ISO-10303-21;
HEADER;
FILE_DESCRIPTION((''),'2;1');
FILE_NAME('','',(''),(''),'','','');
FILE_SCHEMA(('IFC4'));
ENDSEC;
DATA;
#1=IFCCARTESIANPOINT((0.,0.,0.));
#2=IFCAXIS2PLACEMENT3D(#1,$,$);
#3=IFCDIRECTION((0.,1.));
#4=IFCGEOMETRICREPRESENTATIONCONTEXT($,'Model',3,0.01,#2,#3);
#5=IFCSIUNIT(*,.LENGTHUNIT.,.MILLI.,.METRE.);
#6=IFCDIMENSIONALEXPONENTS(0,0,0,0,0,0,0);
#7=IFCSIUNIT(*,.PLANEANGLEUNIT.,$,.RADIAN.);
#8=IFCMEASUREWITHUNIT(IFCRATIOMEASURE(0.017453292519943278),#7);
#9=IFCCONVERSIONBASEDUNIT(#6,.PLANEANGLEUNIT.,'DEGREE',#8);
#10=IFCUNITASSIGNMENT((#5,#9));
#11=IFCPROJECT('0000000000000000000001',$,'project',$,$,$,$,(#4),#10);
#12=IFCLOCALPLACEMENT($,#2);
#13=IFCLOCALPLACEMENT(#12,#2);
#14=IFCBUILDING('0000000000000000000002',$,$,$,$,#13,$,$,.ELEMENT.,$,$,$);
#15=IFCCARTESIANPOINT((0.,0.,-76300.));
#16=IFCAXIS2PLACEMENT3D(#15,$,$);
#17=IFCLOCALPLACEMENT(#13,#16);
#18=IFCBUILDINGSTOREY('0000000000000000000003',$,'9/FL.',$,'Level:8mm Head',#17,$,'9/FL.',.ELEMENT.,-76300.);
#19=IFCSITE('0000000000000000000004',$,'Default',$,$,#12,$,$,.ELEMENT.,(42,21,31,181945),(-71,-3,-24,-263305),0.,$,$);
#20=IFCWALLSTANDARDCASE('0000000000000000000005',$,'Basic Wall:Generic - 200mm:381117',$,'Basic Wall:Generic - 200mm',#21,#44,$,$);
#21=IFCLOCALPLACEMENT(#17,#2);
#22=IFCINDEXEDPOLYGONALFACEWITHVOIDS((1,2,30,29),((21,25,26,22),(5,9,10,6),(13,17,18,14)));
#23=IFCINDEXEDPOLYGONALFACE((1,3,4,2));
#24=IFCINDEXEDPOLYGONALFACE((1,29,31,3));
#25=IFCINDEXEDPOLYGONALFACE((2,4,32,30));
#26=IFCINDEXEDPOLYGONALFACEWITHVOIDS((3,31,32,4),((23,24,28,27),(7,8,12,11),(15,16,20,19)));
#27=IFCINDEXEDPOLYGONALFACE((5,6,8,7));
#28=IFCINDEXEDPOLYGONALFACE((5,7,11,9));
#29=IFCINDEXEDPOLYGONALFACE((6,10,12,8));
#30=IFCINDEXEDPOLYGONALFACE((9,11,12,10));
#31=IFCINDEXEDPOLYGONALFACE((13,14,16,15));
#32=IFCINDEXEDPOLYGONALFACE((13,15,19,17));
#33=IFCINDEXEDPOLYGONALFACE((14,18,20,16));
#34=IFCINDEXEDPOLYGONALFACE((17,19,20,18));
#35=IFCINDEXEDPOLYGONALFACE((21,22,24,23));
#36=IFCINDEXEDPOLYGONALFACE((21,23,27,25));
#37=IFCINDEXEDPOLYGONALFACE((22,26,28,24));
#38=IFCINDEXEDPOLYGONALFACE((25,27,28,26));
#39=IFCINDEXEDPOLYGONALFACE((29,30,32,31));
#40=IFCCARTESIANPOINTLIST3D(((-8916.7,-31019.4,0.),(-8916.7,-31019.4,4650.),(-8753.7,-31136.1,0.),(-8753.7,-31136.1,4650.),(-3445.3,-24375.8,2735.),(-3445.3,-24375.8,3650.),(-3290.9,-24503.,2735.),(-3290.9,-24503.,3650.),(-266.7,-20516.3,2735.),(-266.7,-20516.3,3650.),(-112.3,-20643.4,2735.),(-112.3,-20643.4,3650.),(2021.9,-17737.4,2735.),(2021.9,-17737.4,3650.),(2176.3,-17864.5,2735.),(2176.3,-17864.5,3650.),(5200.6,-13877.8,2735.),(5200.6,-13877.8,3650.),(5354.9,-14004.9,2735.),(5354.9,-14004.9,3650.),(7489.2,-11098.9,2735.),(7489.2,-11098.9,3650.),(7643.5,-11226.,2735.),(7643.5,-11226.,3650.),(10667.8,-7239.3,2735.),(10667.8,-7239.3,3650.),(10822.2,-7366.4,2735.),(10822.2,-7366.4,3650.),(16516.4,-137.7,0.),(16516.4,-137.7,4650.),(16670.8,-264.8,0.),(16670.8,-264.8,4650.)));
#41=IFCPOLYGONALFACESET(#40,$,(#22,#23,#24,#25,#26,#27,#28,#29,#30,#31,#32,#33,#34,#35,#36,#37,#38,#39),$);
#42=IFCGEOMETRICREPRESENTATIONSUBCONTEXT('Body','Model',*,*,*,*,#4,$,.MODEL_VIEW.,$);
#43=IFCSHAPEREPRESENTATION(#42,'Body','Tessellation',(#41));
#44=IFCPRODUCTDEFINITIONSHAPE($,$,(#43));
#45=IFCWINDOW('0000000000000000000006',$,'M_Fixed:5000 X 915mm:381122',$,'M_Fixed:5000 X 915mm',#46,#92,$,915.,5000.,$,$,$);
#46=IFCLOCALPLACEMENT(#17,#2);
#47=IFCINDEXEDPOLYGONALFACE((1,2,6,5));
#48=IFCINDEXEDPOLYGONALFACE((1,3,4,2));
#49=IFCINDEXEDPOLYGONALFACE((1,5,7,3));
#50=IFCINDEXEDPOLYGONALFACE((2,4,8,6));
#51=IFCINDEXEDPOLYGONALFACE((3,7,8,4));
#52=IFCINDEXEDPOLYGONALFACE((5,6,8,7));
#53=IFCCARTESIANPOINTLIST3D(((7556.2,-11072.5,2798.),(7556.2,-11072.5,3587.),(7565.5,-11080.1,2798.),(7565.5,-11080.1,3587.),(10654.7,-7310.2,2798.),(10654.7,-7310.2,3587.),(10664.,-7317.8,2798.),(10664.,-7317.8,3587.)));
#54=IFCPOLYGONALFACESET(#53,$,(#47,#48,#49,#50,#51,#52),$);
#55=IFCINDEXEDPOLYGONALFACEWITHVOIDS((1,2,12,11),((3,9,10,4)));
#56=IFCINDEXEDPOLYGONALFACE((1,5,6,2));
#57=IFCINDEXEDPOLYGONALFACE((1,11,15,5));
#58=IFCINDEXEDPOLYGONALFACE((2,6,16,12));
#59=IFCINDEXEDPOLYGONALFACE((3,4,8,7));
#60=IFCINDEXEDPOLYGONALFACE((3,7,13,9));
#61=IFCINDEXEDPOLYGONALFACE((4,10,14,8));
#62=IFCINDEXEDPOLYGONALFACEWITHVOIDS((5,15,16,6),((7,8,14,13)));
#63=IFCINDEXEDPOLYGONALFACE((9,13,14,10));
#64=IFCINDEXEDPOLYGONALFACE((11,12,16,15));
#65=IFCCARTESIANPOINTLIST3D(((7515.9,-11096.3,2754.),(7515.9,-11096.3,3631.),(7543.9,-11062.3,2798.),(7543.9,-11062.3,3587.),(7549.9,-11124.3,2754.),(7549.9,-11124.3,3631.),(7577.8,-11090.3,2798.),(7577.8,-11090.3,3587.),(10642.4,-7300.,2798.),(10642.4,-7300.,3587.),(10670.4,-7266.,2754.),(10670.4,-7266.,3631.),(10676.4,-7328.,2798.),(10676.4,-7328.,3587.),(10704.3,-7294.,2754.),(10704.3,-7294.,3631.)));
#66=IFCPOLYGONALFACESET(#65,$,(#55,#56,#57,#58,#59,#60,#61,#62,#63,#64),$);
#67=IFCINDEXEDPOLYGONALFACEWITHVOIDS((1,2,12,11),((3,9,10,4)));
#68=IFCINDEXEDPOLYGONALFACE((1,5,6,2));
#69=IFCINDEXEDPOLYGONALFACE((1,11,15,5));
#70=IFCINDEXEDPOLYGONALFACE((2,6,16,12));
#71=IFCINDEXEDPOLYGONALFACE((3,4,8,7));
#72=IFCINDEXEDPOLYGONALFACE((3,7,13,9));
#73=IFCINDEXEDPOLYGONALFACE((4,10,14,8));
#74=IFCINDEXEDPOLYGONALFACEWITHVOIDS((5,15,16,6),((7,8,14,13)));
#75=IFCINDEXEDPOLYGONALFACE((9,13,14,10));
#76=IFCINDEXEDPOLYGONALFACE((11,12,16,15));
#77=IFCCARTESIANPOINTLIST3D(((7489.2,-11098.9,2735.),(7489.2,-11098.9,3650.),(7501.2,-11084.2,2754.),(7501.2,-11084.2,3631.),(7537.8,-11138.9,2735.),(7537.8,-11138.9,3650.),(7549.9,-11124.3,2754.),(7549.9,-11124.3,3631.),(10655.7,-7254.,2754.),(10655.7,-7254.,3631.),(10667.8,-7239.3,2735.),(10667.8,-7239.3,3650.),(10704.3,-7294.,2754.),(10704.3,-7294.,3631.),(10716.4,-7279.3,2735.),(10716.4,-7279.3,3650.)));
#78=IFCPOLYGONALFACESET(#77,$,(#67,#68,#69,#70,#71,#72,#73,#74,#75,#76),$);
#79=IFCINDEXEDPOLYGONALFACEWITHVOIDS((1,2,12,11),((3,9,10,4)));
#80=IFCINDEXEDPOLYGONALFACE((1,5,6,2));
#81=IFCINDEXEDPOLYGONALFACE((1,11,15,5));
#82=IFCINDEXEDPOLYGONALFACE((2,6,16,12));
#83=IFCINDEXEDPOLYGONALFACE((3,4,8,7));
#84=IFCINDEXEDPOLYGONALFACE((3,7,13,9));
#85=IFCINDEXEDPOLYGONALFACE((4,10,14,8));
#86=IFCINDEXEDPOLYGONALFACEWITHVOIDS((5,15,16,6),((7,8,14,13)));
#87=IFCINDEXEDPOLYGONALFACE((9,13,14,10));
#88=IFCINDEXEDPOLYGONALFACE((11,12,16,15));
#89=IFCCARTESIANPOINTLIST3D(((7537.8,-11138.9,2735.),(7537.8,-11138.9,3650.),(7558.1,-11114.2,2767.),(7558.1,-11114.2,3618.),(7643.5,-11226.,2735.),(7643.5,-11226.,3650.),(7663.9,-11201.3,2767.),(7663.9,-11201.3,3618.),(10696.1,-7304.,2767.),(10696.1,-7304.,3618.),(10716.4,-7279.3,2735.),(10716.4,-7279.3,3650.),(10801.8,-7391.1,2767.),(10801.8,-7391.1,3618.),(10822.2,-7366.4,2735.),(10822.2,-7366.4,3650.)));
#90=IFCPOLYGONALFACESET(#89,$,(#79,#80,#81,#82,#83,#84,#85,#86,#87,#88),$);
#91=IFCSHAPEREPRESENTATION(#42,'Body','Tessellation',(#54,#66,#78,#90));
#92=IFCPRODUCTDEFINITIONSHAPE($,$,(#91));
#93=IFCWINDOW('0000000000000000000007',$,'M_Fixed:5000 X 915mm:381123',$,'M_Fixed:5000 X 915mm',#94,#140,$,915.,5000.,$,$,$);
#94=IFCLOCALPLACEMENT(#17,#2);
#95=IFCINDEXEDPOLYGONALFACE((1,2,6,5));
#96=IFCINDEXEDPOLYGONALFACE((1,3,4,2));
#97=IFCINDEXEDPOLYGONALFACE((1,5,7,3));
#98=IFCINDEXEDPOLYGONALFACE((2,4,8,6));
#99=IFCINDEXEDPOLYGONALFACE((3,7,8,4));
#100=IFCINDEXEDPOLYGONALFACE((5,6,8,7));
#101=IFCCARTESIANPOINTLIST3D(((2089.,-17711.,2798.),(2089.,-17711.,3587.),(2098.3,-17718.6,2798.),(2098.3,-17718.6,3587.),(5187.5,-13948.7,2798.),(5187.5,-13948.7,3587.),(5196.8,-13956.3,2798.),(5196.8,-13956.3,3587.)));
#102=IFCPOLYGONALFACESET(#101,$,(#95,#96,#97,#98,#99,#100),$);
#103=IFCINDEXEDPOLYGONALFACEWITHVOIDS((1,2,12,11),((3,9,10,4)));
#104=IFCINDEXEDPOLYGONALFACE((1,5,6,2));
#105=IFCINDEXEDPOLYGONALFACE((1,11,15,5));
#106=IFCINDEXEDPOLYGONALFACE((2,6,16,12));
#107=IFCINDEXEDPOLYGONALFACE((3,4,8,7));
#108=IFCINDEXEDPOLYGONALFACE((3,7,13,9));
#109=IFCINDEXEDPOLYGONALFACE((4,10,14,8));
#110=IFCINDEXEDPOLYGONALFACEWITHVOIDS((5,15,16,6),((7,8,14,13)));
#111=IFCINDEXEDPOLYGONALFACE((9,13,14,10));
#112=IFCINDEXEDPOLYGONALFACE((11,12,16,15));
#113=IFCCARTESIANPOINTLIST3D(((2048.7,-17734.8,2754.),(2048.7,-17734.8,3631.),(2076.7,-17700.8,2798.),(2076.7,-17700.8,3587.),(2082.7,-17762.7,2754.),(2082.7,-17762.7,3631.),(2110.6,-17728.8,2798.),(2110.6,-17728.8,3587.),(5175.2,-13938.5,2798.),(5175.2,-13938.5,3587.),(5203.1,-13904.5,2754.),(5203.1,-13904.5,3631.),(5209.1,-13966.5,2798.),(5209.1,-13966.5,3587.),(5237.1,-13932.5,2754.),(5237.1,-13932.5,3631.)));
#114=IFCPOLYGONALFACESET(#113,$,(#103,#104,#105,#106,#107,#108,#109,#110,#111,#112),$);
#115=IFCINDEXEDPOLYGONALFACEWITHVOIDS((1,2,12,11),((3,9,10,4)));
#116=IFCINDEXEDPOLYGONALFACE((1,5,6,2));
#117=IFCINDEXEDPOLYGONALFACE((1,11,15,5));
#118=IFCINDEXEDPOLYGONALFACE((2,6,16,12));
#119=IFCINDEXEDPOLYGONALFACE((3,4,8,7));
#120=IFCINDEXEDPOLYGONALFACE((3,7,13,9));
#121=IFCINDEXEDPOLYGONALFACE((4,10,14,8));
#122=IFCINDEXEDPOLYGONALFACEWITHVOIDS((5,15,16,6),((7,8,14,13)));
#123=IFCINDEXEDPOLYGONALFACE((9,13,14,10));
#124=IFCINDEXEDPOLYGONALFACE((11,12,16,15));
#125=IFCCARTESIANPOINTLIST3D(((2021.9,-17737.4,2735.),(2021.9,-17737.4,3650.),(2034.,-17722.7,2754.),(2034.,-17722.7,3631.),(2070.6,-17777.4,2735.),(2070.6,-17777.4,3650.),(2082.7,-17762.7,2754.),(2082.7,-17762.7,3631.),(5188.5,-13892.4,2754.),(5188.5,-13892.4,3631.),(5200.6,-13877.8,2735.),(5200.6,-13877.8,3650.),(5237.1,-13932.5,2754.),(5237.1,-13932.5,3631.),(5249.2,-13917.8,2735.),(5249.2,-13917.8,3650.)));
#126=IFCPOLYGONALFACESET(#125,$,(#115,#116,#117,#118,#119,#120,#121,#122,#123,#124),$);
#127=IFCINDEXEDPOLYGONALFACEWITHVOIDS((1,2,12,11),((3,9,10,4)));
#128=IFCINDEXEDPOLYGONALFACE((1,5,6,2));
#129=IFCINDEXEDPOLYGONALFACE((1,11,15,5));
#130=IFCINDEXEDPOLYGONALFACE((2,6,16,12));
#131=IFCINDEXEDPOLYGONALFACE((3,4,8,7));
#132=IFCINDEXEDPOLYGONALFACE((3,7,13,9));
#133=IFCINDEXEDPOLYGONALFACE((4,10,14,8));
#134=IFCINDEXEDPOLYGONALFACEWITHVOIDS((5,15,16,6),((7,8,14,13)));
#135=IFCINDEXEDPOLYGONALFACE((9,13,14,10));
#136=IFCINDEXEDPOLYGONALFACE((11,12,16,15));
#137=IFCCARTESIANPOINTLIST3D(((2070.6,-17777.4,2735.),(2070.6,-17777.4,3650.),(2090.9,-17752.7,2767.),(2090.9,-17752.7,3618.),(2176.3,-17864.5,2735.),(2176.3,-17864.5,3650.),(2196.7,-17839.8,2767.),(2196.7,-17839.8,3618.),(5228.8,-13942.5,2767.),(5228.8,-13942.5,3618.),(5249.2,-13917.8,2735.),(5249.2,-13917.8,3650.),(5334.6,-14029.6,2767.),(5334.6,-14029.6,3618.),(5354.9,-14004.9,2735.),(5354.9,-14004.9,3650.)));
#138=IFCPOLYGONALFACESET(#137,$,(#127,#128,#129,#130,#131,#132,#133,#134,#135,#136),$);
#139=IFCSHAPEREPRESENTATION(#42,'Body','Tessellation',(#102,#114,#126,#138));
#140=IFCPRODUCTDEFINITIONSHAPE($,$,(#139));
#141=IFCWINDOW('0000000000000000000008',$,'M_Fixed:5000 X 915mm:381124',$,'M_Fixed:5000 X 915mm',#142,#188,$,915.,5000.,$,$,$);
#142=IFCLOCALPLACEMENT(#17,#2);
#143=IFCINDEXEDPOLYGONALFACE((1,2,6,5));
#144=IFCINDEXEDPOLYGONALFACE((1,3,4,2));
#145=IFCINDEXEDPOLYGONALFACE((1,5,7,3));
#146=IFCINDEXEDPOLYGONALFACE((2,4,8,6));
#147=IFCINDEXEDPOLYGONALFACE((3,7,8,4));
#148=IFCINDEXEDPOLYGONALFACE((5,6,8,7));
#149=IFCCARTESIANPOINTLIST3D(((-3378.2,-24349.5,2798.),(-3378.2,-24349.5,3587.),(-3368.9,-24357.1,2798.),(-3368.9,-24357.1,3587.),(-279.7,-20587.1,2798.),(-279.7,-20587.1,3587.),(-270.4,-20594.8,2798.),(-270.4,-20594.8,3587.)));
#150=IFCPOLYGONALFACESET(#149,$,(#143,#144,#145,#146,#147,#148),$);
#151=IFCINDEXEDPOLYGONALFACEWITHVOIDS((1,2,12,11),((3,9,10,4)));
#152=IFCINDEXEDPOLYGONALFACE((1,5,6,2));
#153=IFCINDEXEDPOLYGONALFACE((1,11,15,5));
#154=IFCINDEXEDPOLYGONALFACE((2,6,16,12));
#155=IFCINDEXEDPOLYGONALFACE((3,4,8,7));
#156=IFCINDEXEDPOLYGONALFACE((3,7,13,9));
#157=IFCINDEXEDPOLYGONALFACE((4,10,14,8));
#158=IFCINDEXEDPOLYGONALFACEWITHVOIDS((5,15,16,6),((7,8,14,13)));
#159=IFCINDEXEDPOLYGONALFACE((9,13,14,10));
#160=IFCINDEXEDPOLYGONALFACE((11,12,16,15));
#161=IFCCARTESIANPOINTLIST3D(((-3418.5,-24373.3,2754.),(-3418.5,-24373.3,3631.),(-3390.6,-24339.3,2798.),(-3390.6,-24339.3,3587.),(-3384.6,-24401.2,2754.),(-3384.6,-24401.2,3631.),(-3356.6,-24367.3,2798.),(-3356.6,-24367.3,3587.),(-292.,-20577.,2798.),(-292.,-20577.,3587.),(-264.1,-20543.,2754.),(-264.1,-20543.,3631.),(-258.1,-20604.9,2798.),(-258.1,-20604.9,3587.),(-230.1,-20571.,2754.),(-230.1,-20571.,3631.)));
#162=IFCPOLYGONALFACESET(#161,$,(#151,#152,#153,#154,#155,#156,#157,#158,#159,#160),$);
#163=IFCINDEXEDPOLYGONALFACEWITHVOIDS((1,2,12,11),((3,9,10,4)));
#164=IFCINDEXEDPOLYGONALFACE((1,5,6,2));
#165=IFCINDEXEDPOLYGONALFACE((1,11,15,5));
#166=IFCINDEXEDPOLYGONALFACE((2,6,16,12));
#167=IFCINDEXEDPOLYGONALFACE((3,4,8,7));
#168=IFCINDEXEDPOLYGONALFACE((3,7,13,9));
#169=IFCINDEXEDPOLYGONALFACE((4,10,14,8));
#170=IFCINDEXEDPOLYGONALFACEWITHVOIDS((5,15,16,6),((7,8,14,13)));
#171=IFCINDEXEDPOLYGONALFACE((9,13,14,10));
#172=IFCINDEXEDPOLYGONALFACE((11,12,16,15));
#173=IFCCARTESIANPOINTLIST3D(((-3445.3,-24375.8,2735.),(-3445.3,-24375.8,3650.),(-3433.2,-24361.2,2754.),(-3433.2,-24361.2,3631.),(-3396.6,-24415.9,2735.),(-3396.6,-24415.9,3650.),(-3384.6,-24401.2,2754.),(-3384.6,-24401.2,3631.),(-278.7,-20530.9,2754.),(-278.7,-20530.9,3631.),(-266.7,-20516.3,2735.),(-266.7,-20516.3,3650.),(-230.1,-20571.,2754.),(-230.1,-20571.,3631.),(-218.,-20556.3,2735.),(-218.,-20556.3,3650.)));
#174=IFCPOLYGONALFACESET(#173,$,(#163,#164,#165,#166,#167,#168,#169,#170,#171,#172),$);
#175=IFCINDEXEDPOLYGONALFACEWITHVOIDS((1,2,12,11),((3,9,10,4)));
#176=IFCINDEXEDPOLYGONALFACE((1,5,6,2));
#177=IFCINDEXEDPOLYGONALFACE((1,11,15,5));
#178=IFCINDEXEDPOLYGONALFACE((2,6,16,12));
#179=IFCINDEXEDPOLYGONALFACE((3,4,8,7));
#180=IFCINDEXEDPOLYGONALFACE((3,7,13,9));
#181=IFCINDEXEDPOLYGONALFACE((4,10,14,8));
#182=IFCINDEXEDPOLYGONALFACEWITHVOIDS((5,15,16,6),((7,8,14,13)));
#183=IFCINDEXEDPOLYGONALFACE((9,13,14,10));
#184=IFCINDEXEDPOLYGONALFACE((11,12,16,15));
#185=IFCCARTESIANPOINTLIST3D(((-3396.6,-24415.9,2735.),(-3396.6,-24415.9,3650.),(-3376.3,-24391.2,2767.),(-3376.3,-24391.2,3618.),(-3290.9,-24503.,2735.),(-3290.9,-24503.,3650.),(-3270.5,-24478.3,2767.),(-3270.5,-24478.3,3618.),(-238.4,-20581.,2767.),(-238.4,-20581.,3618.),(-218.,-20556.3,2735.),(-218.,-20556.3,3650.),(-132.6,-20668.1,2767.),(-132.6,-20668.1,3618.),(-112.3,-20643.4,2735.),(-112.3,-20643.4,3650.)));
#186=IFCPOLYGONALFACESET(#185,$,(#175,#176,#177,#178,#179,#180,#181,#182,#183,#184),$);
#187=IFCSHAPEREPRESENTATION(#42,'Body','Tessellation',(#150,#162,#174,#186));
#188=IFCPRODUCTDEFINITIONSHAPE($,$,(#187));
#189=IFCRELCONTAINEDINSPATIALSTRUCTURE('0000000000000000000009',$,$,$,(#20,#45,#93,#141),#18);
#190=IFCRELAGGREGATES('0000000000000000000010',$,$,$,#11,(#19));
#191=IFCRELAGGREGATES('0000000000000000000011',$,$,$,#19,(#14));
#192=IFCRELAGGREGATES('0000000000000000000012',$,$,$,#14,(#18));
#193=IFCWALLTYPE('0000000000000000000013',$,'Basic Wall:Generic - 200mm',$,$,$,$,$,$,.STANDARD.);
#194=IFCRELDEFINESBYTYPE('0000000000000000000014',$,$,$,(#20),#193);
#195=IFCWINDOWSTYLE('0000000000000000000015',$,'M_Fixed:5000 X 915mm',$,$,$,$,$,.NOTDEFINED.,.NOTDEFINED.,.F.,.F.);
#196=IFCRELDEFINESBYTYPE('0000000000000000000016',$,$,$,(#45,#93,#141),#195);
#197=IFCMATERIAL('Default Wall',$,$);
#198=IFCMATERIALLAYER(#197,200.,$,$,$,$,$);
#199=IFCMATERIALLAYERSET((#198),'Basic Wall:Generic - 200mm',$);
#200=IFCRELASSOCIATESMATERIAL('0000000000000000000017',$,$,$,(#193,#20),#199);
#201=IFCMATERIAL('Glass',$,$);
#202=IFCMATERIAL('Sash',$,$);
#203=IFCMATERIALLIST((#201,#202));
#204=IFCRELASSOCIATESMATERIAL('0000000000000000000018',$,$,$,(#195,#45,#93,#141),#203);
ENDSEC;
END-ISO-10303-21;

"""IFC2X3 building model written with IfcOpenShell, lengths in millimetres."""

from ifc_helpers import new_model, entity, si_unit, converted_unit, direction, frame, frame_2d, origin, place, context, subcontext, project, spatial, polyline, rectangle, outline, extrude, source, transform, mapped, material, material_list, layer, layer_set, layer_usage, type_object, type_shapes, element, fill, save


model = new_model("IFC2X3")

# Units and contexts
model_context = context("Model", 3, precision=0.01, world=origin(), true_north=direction((0.0, 1.0)))
body_context = subcontext(model_context, "Body", "Model", "MODEL_VIEW")
ifc_project = project(units=[si_unit("LENGTHUNIT", "METRE", prefix="MILLI"), converted_unit("PLANEANGLEUNIT", "DEGREE", entity("IfcRatioMeasure", 0.017453292519943278), si_unit("PLANEANGLEUNIT", "RADIAN"), dimensions=[0, 0, 0, 0, 0, 0, 0])], contexts=[model_context])

# Site, building, storey
site_placement = place(None, origin())
site = spatial("IfcSite", under=ifc_project, at=site_placement, Name="Default", CompositionType="ELEMENT", RefLatitude=(42, 21, 31, 181945), RefLongitude=(-71, -3, -24, -263305), RefElevation=0.0)
building_placement = place(site_placement, origin())
building = spatial("IfcBuilding", under=site, at=building_placement, CompositionType="ELEMENT")
storey_placement = place(building_placement, frame((0.0, 0.0, -76300.0)))
storey = spatial("IfcBuildingStorey", under=building, at=storey_placement, Name="9/FL.", ObjectType="Level:8mm Head", LongName="9/FL.", CompositionType="ELEMENT", Elevation=-76300.0)

# Shared definitions
ifc_material_1 = material(Name="Default Wall")
ifc_layer = layer(ifc_material_1, 200.0)
ifc_layer_set = layer_set([ifc_layer], Name="Basic Wall:Generic - 200mm")
ifc_layer_usage = layer_usage(ifc_layer_set, "AXIS2", "NEGATIVE", 100.0)
wall_type = type_object("IfcWallType", Name="Basic Wall:Generic - 200mm", PredefinedType="STANDARD", material=ifc_layer_set)

# Wall, openings, windows
wall_1_placement = place(storey_placement, frame((17102.2, 416.3, 0.0), z_axis=(0.0, 0.0, 1.0), x_axis=(-0.635723, -0.771917, 0.0)))
wall_1 = element("IfcWallStandardCase", 1, at=wall_1_placement, inside=storey, type_object=wall_type, material=ifc_layer_usage, Name="Basic Wall:Generic - 200mm:381117", ObjectType="Basic Wall:Generic - 200mm", context=body_context, shape_type="SweptSolid", body=[
    extrude(outline(polyline([(40806.5, -100.0), (40793.0, 100.0), (37219.3, 100.0), (37019.3, 100.0), (800.0, 100.0), (800.0, -100.0), (37019.3, -100.0), (37219.3, -100.0), (40806.5, -100.0)])), origin(), (0.0, 0.0, 1.0), 4650.0),
])
opening_1_placement = place(wall_1_placement, origin())
element("IfcOpeningElement", 2, at=opening_1_placement, cuts=wall_1, ObjectType="Opening", context=body_context, shape_type="SweptSolid", body=[
    extrude(rectangle(XDim=1000.0, YDim=1012.7, at=frame_2d((0.0, 0.0), x_axis=(1.0, 0.0))), frame((293.7, -183.3, 500.0), z_axis=(0.0, 1.0, 0.0), x_axis=(0.0, 0.0, -1.0)), (0.0, 0.0, 1.0), 1010.1),
])
opening_2_placement = place(wall_1_placement, frame((15000.0, 100.0, 2735.0)))
opening_2 = element("IfcOpeningElement", 3, at=opening_2_placement, cuts=wall_1, ObjectType="Opening", context=body_context, shape_type="SweptSolid", body=[
    extrude(rectangle(XDim=915.0, YDim=5000.0, at=frame_2d((457.5, 2500.0), x_axis=(1.0, 0.0))), frame((0.0, 0.0, 0.0), z_axis=(0.0, -1.0, 0.0), x_axis=(0.0, 0.0, 1.0)), (0.0, 0.0, 1.0), 200.0),
])
opening_3_placement = place(wall_1_placement, frame((23600.0, 100.0, 2735.0)))
opening_3 = element("IfcOpeningElement", 4, at=opening_3_placement, cuts=wall_1, ObjectType="Opening", context=body_context, shape_type="SweptSolid", body=[
    extrude(rectangle(XDim=915.0, YDim=5000.0, at=frame_2d((457.5, 2500.0), x_axis=(1.0, 0.0))), frame((0.0, 0.0, 0.0), z_axis=(0.0, -1.0, 0.0), x_axis=(0.0, 0.0, 1.0)), (0.0, 0.0, 1.0), 200.0),
])
opening_4_placement = place(wall_1_placement, frame((32200.0, 100.0, 2735.0)))
opening_4 = element("IfcOpeningElement", 5, at=opening_4_placement, cuts=wall_1, ObjectType="Opening", context=body_context, shape_type="SweptSolid", body=[
    extrude(rectangle(XDim=915.0, YDim=5000.0, at=frame_2d((457.5, 2500.0), x_axis=(1.0, 0.0))), frame((0.0, 0.0, 0.0), z_axis=(0.0, -1.0, 0.0), x_axis=(0.0, 0.0, 1.0)), (0.0, 0.0, 1.0), 200.0),
])
ifc_material_2 = material(Name="Glass")
ifc_material_3 = material(Name="Sash")
ifc_material_list = material_list([ifc_material_2, ifc_material_3])
window_style_1 = type_object("IfcWindowStyle", Name="M_Fixed:5000 X 915mm", ConstructionType="NOTDEFINED", OperationType="NOTDEFINED", ParameterTakesPrecedence=False, Sizeable=False, material=ifc_material_list)
shared_shape_1 = source(origin(), body_context, "Body", "SweptSolid", [
    extrude(rectangle(XDim=12.0, YDim=4874.0, at=frame_2d((0.0, 0.0), x_axis=(1.0, 0.0))), frame((2500.0, 159.0, 63.0), z_axis=(0.0, 0.0, 1.0), x_axis=(0.0, -1.0, 0.0)), (0.0, 0.0, 1.0), 789.0),
    extrude(outline(polyline([(-2481.0, -438.5), (2481.0, -438.5), (2481.0, 438.5), (-2481.0, 438.5), (-2481.0, -438.5)]), holes=[polyline([(-2437.0, -394.5), (-2437.0, 394.5), (2437.0, 394.5), (2437.0, -394.5), (-2437.0, -394.5)])]), frame((2500.0, 137.0, 457.5), z_axis=(0.0, 1.0, 0.0), x_axis=(1.0, 0.0, 0.0)), (0.0, 0.0, 1.0), 44.0),
    extrude(outline(polyline([(-2500.0, -457.5), (2500.0, -457.5), (2500.0, 457.5), (-2500.0, 457.5), (-2500.0, -457.5)]), holes=[polyline([(-2481.0, -438.5), (-2481.0, 438.5), (2481.0, 438.5), (2481.0, -438.5), (-2481.0, -438.5)])]), frame((2500.0, 137.0, 457.5), z_axis=(0.0, 1.0, 0.0), x_axis=(1.0, 0.0, 0.0)), (0.0, 0.0, 1.0), 63.0),
    extrude(outline(polyline([(-2500.0, -457.5), (2500.0, -457.5), (2500.0, 457.5), (-2500.0, 457.5), (-2500.0, -457.5)]), holes=[polyline([(-2468.0, -425.5), (-2468.0, 425.5), (2468.0, 425.5), (2468.0, -425.5), (-2468.0, -425.5)])]), frame((2500.0, 0.0, 457.5), z_axis=(0.0, 1.0, 0.0), x_axis=(1.0, 0.0, 0.0)), (0.0, 0.0, 1.0), 137.0),
])
type_shapes(window_style_1, [shared_shape_1])
window_1_placement = place(opening_2_placement, frame((0.0, 0.0, 0.0), z_axis=(0.0, 0.0, 1.0), x_axis=(-1.0, 0.0, 0.0)))
window_1 = element("IfcWindow", 6, at=window_1_placement, inside=storey, type_object=window_style_1, material=ifc_material_list, Name="M_Fixed:5000 X 915mm:381122", ObjectType="M_Fixed:5000 X 915mm", OverallHeight=915.0, OverallWidth=5000.0, context=body_context, shape_type="MappedRepresentation", body=[
    mapped(shared_shape_1, transform((0.0, 0.0, 0.0), scale=1.0)),
])
fill(opening_2, window_1)
window_2_placement = place(opening_3_placement, frame((0.0, 0.0, 0.0), z_axis=(0.0, 0.0, 1.0), x_axis=(-1.0, 0.0, 0.0)))
window_2 = element("IfcWindow", 7, at=window_2_placement, inside=storey, type_object=window_style_1, material=ifc_material_list, Name="M_Fixed:5000 X 915mm:381123", ObjectType="M_Fixed:5000 X 915mm", OverallHeight=915.0, OverallWidth=5000.0, context=body_context, shape_type="MappedRepresentation", body=[
    mapped(shared_shape_1, transform((0.0, 0.0, 0.0), scale=1.0)),
])
fill(opening_3, window_2)
window_3_placement = place(opening_4_placement, frame((0.0, 0.0, 0.0), z_axis=(0.0, 0.0, 1.0), x_axis=(-1.0, 0.0, 0.0)))
window_3 = element("IfcWindow", 8, at=window_3_placement, inside=storey, type_object=window_style_1, material=ifc_material_list, Name="M_Fixed:5000 X 915mm:381124", ObjectType="M_Fixed:5000 X 915mm", OverallHeight=915.0, OverallWidth=5000.0, context=body_context, shape_type="MappedRepresentation", body=[
    mapped(shared_shape_1, transform((0.0, 0.0, 0.0), scale=1.0)),
])
fill(opening_4, window_3)

save(model, "model.ifc")
